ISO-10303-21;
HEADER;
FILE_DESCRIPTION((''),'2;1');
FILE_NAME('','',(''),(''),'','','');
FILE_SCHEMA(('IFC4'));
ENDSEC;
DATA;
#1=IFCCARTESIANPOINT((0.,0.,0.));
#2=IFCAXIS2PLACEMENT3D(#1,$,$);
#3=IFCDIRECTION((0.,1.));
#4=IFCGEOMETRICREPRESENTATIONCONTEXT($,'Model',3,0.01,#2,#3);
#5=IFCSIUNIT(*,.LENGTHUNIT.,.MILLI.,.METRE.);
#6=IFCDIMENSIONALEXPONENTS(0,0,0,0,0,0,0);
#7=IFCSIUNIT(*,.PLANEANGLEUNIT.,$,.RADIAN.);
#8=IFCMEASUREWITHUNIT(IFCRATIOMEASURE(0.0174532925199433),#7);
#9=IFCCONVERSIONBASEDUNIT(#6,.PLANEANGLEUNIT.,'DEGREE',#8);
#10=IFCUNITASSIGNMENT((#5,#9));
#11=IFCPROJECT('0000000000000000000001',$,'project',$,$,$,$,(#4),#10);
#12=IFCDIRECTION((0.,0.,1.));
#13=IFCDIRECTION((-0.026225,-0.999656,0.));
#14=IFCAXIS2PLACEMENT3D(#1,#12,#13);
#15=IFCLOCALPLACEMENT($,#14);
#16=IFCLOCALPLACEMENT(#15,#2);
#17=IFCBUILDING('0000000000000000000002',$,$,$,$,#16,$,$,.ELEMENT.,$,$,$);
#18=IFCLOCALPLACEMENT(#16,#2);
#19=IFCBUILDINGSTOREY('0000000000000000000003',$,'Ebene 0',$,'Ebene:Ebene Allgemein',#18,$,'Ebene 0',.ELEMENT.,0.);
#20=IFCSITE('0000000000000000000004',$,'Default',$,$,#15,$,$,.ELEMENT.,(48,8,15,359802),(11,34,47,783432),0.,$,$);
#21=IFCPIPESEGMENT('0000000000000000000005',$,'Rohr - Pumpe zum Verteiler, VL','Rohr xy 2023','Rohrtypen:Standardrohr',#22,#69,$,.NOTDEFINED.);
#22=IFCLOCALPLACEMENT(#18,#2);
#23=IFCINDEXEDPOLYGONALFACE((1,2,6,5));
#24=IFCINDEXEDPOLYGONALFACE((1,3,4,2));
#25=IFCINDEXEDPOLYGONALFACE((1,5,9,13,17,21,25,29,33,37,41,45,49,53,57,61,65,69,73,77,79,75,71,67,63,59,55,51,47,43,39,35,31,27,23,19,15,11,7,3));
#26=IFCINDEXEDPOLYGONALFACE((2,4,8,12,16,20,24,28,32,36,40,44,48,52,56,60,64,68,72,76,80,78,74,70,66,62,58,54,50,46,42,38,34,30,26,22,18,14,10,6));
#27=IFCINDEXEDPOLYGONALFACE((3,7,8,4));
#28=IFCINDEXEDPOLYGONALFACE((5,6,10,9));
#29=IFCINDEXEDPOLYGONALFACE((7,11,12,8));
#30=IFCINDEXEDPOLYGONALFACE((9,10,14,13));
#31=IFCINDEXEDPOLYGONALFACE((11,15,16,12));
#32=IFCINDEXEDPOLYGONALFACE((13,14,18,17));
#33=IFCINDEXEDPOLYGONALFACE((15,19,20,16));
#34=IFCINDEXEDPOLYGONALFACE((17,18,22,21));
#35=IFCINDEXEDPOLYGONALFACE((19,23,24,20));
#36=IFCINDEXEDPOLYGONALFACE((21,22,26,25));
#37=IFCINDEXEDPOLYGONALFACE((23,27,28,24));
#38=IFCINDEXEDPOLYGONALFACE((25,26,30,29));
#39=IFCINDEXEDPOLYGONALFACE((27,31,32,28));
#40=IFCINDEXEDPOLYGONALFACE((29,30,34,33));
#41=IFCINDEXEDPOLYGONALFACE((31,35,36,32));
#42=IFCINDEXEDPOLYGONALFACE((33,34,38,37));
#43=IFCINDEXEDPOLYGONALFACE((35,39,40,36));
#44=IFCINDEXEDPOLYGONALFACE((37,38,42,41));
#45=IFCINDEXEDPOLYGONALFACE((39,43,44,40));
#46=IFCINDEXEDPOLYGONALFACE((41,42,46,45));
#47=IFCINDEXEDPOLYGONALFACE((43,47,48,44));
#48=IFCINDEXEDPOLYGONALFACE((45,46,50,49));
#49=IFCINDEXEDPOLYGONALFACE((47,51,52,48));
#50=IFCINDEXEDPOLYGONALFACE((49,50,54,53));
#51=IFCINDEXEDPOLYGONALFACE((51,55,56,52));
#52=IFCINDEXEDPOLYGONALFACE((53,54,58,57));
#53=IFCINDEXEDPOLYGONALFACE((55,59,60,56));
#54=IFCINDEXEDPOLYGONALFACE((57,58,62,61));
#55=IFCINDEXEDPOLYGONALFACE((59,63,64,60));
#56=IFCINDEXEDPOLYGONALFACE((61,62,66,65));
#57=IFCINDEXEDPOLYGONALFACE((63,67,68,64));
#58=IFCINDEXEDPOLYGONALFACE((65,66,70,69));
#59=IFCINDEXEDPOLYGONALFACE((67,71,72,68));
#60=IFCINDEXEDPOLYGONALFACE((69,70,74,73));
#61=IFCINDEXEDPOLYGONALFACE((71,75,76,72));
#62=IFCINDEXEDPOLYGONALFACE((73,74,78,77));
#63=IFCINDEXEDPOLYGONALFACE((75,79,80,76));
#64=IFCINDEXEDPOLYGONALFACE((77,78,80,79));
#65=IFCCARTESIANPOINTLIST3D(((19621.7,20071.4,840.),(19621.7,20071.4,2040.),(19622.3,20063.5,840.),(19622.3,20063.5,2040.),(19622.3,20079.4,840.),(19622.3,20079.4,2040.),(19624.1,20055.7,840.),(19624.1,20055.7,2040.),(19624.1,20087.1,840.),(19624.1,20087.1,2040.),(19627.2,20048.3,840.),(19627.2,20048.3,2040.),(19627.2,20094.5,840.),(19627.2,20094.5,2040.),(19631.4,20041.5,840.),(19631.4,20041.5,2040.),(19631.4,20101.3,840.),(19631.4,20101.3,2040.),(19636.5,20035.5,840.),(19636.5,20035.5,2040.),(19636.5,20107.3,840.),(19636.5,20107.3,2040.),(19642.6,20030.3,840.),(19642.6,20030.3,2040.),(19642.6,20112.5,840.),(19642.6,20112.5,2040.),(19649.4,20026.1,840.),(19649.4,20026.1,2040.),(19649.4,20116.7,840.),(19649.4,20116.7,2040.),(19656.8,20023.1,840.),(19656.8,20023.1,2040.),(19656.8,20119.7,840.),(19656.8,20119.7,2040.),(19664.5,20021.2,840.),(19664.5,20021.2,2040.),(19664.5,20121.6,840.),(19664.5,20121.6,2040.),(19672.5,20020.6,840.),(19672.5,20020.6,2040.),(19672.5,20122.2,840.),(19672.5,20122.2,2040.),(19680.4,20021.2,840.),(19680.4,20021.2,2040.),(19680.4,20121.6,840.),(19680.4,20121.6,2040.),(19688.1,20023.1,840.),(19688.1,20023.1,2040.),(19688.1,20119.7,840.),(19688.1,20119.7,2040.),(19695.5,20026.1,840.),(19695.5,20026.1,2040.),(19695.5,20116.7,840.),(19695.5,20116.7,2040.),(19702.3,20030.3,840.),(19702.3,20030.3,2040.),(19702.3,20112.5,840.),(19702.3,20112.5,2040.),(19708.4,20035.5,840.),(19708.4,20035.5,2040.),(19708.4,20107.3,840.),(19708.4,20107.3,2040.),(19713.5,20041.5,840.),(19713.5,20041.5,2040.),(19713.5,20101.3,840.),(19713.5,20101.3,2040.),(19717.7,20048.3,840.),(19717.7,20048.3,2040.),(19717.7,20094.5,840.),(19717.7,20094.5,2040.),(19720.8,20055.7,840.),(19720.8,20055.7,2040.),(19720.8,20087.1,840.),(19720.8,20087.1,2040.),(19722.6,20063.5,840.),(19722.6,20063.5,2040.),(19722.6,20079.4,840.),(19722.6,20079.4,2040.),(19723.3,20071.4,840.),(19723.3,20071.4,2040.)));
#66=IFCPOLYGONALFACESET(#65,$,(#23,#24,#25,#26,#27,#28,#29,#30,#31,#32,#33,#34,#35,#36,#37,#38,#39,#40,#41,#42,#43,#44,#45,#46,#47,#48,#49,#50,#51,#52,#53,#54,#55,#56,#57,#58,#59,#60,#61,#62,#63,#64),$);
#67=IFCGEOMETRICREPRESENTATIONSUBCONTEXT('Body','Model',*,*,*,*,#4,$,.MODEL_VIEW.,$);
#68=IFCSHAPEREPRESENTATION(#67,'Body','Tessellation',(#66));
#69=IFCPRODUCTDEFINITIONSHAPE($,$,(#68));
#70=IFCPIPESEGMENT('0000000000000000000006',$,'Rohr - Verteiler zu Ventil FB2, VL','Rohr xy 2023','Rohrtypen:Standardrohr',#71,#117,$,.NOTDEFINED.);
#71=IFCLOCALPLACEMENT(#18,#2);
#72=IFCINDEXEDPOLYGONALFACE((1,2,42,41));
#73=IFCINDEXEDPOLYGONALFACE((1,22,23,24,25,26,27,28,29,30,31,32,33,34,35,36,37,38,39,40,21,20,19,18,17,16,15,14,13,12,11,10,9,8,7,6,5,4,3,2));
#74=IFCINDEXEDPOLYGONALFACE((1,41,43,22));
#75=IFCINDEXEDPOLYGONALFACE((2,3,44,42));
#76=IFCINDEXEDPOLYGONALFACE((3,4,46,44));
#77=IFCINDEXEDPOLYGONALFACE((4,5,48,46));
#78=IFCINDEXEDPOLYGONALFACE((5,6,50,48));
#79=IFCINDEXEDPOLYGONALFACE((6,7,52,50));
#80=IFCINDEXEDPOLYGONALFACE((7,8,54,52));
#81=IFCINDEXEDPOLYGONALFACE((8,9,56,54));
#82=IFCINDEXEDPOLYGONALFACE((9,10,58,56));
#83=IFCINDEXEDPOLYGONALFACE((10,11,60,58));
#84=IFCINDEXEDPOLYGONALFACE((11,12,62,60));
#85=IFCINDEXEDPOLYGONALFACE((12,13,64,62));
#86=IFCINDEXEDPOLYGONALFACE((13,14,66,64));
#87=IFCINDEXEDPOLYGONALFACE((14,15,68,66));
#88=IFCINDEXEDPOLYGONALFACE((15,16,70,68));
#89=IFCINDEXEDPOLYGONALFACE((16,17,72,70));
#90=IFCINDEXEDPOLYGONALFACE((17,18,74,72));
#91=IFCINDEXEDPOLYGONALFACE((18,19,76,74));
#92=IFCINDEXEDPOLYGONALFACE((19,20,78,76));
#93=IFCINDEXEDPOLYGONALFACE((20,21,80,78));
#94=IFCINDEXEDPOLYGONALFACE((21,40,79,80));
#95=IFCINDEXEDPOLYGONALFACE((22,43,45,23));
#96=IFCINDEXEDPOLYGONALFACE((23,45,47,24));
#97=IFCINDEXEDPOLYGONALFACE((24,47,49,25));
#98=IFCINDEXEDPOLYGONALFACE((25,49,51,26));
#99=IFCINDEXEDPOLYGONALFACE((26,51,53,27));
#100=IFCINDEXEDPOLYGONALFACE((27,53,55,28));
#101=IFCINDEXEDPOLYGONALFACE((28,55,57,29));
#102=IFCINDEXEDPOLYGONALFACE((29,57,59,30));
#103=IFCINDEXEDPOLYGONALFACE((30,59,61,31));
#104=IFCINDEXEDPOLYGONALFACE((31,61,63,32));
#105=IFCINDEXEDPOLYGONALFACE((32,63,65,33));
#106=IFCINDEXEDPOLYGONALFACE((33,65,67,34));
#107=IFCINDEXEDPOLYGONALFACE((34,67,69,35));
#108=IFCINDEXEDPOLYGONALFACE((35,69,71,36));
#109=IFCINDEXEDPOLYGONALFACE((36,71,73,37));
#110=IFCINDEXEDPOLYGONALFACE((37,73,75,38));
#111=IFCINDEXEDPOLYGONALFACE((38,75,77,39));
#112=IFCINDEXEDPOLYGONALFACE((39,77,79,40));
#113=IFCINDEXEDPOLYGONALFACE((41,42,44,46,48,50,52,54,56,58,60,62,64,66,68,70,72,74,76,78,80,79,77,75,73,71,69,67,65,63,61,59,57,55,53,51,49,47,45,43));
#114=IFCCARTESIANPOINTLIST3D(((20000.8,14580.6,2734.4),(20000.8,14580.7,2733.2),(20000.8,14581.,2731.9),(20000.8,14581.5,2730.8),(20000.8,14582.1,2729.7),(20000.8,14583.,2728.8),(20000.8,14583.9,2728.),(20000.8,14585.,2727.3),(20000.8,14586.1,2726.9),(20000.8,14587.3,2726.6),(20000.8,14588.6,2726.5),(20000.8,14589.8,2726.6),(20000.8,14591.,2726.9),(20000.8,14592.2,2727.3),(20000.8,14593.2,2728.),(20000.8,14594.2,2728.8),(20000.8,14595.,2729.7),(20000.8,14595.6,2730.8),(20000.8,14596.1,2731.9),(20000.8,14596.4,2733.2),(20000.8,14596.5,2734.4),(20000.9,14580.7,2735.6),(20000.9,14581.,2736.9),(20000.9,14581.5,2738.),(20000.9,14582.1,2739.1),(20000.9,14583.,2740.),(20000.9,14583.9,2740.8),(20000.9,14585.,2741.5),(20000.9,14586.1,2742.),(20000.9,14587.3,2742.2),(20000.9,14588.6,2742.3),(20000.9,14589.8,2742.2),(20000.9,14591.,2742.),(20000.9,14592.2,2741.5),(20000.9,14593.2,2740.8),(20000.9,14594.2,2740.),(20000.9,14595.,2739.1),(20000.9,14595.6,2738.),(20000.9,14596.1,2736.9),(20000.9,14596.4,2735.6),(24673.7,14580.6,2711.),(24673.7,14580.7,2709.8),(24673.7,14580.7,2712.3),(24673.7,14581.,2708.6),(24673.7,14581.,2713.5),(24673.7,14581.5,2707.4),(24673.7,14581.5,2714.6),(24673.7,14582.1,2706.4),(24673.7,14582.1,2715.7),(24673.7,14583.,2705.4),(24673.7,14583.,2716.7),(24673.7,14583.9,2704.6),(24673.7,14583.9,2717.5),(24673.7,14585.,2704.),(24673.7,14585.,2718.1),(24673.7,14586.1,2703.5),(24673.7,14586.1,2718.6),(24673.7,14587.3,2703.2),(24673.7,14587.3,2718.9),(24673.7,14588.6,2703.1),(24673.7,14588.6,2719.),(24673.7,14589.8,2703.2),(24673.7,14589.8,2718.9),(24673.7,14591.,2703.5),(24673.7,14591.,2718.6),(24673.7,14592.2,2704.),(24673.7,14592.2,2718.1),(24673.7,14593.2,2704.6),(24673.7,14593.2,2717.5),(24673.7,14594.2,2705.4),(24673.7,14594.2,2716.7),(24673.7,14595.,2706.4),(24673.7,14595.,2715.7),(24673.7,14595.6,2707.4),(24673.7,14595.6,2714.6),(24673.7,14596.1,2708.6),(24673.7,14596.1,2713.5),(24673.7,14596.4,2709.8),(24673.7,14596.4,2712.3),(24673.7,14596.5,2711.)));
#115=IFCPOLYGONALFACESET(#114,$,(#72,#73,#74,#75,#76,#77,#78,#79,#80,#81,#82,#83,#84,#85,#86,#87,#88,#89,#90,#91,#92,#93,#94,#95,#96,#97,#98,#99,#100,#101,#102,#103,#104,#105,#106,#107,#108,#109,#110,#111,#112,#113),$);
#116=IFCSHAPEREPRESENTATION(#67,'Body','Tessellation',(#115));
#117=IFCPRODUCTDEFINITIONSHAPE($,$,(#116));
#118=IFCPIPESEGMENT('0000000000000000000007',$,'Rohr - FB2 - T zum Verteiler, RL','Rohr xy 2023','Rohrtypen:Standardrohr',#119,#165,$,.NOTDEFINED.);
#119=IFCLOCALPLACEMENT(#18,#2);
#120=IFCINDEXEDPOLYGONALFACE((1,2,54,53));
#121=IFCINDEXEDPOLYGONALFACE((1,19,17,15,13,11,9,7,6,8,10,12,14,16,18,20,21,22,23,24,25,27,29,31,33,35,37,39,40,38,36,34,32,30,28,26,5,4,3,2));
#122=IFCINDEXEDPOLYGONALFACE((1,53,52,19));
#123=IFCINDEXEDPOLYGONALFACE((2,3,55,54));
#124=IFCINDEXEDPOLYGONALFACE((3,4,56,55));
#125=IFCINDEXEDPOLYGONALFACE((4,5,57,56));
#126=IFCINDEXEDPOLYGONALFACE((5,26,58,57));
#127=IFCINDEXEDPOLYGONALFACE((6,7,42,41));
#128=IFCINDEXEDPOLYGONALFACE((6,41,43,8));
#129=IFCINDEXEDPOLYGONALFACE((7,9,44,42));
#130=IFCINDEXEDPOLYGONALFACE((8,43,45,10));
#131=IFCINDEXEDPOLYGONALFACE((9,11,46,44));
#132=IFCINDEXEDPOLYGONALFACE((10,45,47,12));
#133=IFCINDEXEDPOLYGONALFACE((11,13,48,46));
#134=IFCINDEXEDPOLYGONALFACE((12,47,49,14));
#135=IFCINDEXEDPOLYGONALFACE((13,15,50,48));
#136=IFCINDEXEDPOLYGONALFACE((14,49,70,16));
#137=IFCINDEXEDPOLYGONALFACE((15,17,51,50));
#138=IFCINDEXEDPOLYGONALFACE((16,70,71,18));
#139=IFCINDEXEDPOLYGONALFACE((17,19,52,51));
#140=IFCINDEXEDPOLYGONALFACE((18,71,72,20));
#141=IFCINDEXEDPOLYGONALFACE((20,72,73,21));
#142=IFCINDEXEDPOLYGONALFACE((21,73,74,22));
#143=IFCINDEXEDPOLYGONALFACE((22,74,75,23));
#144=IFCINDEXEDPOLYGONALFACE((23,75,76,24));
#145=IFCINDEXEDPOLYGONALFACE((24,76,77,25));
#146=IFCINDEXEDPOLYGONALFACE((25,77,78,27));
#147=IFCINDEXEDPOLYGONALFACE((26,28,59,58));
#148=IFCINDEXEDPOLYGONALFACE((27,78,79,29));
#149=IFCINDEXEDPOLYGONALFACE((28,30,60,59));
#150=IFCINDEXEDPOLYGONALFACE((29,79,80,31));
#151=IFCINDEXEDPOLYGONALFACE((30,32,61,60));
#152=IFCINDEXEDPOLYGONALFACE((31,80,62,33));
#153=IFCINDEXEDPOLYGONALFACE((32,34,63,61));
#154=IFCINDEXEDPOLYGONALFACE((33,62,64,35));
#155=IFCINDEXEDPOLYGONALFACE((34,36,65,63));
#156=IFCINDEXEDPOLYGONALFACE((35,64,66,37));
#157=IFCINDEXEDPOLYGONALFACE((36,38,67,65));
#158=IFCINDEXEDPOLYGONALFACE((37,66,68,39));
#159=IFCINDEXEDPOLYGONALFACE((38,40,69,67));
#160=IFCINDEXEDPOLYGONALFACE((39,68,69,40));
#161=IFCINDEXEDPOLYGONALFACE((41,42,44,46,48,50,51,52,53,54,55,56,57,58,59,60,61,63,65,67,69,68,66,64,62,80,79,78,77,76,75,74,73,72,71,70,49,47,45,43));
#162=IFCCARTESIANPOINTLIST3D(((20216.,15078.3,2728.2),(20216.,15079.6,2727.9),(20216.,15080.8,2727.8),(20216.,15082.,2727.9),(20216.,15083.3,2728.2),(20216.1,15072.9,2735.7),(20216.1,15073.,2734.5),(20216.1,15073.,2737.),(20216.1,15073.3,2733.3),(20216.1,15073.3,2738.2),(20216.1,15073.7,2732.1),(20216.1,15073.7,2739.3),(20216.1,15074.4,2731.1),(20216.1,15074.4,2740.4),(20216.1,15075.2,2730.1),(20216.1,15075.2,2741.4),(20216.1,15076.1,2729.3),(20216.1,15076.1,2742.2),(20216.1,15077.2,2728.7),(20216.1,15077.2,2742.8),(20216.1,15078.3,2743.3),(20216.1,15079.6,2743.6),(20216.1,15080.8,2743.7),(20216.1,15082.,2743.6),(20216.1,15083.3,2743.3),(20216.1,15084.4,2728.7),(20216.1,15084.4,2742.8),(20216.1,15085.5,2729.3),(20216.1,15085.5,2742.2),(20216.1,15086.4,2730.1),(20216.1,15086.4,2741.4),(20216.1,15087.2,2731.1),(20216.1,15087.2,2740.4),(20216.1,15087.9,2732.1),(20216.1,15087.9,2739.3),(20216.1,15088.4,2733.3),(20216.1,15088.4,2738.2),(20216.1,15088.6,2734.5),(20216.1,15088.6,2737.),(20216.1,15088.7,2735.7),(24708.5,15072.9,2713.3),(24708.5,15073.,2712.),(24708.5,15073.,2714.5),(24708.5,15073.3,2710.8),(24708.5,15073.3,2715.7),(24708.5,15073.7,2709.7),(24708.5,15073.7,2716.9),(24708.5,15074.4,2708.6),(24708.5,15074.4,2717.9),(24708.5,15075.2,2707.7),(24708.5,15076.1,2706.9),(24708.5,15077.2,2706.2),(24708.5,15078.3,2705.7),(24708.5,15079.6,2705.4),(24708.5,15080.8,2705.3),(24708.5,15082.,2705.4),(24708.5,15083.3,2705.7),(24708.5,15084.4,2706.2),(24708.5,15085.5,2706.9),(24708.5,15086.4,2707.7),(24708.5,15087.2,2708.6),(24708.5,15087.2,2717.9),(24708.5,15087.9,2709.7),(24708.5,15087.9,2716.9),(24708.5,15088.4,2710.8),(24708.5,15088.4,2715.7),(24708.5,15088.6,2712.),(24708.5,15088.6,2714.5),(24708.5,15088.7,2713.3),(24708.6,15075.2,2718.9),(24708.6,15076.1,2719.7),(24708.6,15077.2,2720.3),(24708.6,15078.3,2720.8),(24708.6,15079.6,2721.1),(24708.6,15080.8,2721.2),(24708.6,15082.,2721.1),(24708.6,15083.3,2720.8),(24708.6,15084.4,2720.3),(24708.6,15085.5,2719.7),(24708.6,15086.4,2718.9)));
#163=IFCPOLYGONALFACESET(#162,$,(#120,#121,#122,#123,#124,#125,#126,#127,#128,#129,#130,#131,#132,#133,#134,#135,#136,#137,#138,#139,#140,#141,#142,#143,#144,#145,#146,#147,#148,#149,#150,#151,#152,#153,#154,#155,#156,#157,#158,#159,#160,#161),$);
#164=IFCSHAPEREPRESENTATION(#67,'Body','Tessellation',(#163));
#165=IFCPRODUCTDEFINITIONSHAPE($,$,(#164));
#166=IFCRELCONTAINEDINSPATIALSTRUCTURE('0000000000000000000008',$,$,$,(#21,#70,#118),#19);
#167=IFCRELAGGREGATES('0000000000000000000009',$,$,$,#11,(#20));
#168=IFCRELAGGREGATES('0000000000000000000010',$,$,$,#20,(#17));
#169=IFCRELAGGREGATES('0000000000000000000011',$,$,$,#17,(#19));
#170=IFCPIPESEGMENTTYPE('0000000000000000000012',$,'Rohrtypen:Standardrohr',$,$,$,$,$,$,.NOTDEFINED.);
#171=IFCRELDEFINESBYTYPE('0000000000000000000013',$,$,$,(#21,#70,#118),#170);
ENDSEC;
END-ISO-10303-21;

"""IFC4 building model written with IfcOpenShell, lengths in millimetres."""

from ifc_helpers import new_model, entity, si_unit, converted_unit, direction, frame, origin, place, context, subcontext, project, spatial, indexed_curve, outline, extrude, type_object, element, save


model = new_model("IFC4")

# Units and contexts
model_context = context("Model", 3, precision=0.01, world=origin(), true_north=direction((0.0, 1.0)))
body_context = subcontext(model_context, "Body", "Model", "MODEL_VIEW")
ifc_project = project(units=[si_unit("LENGTHUNIT", "METRE", prefix="MILLI"), converted_unit("PLANEANGLEUNIT", "DEGREE", entity("IfcRatioMeasure", 0.0174532925199433), si_unit("PLANEANGLEUNIT", "RADIAN"), dimensions=[0, 0, 0, 0, 0, 0, 0])], contexts=[model_context])

# Site, building, storey
site_placement = place(None, frame((0.0, 0.0, 0.0), z_axis=(0.0, 0.0, 1.0), x_axis=(-0.026225, -0.999656, 0.0)))
site = spatial("IfcSite", under=ifc_project, at=site_placement, Name="Default", CompositionType="ELEMENT", RefLatitude=(48, 8, 15, 359802), RefLongitude=(11, 34, 47, 783432), RefElevation=0.0)
building_placement = place(site_placement, origin())
building = spatial("IfcBuilding", under=site, at=building_placement, CompositionType="ELEMENT")
storey_placement = place(building_placement, origin())
storey = spatial("IfcBuildingStorey", under=building, at=storey_placement, Name="Ebene 0", ObjectType="Ebene:Ebene Allgemein", LongName="Ebene 0", CompositionType="ELEMENT", Elevation=0.0)

# Pipe segments
pipe_segment_type = type_object("IfcPipeSegmentType", Name="Rohrtypen:Standardrohr", PredefinedType="NOTDEFINED")
pipe_segment_1_placement = place(storey_placement, origin())
element("IfcPipeSegment", 1, at=pipe_segment_1_placement, inside=storey, type_object=pipe_segment_type, Name="Rohr - Pumpe zum Verteiler, VL", Description="Rohr xy 2023", ObjectType="Rohrtypen:Standardrohr", PredefinedType="NOTDEFINED", context=body_context, shape_type="SweptSolid", body=[
    extrude(outline(indexed_curve([(50.8, 0.0), (50.2, 7.9), (48.3, 15.7), (45.3, 23.1), (41.1, 29.9), (35.9, 35.9), (29.9, 41.1), (23.1, 45.3), (15.7, 48.3), (7.9, 50.2), (0.0, 50.8), (-7.9, 50.2), (-15.7, 48.3), (-23.1, 45.3), (-29.9, 41.1), (-35.9, 35.9), (-41.1, 29.9), (-45.3, 23.1), (-48.3, 15.7), (-50.2, 7.9), (-50.8, 0.0), (-50.2, -7.9), (-48.3, -15.7), (-45.3, -23.1), (-41.1, -29.9), (-35.9, -35.9), (-29.9, -41.1), (-23.1, -45.3), (-15.7, -48.3), (-7.9, -50.2), (0.0, -50.8), (7.9, -50.2), (15.7, -48.3), (23.1, -45.3), (29.9, -41.1), (35.9, -35.9), (41.1, -29.9), (45.3, -23.1), (48.3, -15.7), (50.2, -7.9), (50.8, 0.0)], self_intersect=False)), frame((19672.5, 20071.4, 840.0), z_axis=(0.0, 0.0, 1.0), x_axis=(-1.0, 0.0, 0.0)), (0.0, 0.0, 1.0), 1200.0),
])
pipe_segment_2_placement = place(storey_placement, origin())
element("IfcPipeSegment", 2, at=pipe_segment_2_placement, inside=storey, type_object=pipe_segment_type, Name="Rohr - Verteiler zu Ventil FB2, VL", Description="Rohr xy 2023", ObjectType="Rohrtypen:Standardrohr", PredefinedType="NOTDEFINED", context=body_context, shape_type="SweptSolid", body=[
    extrude(outline(indexed_curve([(7.9, 0.0), (7.8, 1.2), (7.6, 2.5), (7.1, 3.6), (6.4, 4.7), (5.6, 5.6), (4.7, 6.4), (3.6, 7.1), (2.5, 7.6), (1.2, 7.8), (0.0, 7.9), (-1.2, 7.8), (-2.5, 7.6), (-3.6, 7.1), (-4.7, 6.4), (-5.6, 5.6), (-6.4, 4.7), (-7.1, 3.6), (-7.6, 2.5), (-7.8, 1.2), (-7.9, 0.0), (-7.8, -1.2), (-7.6, -2.5), (-7.1, -3.6), (-6.4, -4.7), (-5.6, -5.6), (-4.7, -6.4), (-3.6, -7.1), (-2.5, -7.6), (-1.2, -7.8), (0.0, -7.9), (1.2, -7.8), (2.5, -7.6), (3.6, -7.1), (4.7, -6.4), (5.6, -5.6), (6.4, -4.7), (7.1, -3.6), (7.6, -2.5), (7.8, -1.2), (7.9, 0.0)], self_intersect=False)), frame((24673.7, 14588.6, 2711.0), z_axis=(-0.999988, 0.0, 0.005), x_axis=(0.0, 1.0, 0.0)), (0.0, 0.0, 1.0), 4672.9),
])
pipe_segment_3_placement = place(storey_placement, origin())
element("IfcPipeSegment", 3, at=pipe_segment_3_placement, inside=storey, type_object=pipe_segment_type, Name="Rohr - FB2 - T zum Verteiler, RL", Description="Rohr xy 2023", ObjectType="Rohrtypen:Standardrohr", PredefinedType="NOTDEFINED", context=body_context, shape_type="SweptSolid", body=[
    extrude(outline(indexed_curve([(7.9, 0.0), (7.8, 1.2), (7.6, 2.5), (7.1, 3.6), (6.4, 4.7), (5.6, 5.6), (4.7, 6.4), (3.6, 7.1), (2.5, 7.6), (1.2, 7.8), (0.0, 7.9), (-1.2, 7.8), (-2.5, 7.6), (-3.6, 7.1), (-4.7, 6.4), (-5.6, 5.6), (-6.4, 4.7), (-7.1, 3.6), (-7.6, 2.5), (-7.8, 1.2), (-7.9, 0.0), (-7.8, -1.2), (-7.6, -2.5), (-7.1, -3.6), (-6.4, -4.7), (-5.6, -5.6), (-4.7, -6.4), (-3.6, -7.1), (-2.5, -7.6), (-1.2, -7.8), (0.0, -7.9), (1.2, -7.8), (2.5, -7.6), (3.6, -7.1), (4.7, -6.4), (5.6, -5.6), (6.4, -4.7), (7.1, -3.6), (7.6, -2.5), (7.8, -1.2), (7.9, 0.0)], self_intersect=False)), frame((24708.5, 15080.8, 2713.3), z_axis=(-0.999988, 0.0, 0.005), x_axis=(0.0, 1.0, 0.0)), (0.0, 0.0, 1.0), 4492.5),
])

save(model, "model.ifc")
